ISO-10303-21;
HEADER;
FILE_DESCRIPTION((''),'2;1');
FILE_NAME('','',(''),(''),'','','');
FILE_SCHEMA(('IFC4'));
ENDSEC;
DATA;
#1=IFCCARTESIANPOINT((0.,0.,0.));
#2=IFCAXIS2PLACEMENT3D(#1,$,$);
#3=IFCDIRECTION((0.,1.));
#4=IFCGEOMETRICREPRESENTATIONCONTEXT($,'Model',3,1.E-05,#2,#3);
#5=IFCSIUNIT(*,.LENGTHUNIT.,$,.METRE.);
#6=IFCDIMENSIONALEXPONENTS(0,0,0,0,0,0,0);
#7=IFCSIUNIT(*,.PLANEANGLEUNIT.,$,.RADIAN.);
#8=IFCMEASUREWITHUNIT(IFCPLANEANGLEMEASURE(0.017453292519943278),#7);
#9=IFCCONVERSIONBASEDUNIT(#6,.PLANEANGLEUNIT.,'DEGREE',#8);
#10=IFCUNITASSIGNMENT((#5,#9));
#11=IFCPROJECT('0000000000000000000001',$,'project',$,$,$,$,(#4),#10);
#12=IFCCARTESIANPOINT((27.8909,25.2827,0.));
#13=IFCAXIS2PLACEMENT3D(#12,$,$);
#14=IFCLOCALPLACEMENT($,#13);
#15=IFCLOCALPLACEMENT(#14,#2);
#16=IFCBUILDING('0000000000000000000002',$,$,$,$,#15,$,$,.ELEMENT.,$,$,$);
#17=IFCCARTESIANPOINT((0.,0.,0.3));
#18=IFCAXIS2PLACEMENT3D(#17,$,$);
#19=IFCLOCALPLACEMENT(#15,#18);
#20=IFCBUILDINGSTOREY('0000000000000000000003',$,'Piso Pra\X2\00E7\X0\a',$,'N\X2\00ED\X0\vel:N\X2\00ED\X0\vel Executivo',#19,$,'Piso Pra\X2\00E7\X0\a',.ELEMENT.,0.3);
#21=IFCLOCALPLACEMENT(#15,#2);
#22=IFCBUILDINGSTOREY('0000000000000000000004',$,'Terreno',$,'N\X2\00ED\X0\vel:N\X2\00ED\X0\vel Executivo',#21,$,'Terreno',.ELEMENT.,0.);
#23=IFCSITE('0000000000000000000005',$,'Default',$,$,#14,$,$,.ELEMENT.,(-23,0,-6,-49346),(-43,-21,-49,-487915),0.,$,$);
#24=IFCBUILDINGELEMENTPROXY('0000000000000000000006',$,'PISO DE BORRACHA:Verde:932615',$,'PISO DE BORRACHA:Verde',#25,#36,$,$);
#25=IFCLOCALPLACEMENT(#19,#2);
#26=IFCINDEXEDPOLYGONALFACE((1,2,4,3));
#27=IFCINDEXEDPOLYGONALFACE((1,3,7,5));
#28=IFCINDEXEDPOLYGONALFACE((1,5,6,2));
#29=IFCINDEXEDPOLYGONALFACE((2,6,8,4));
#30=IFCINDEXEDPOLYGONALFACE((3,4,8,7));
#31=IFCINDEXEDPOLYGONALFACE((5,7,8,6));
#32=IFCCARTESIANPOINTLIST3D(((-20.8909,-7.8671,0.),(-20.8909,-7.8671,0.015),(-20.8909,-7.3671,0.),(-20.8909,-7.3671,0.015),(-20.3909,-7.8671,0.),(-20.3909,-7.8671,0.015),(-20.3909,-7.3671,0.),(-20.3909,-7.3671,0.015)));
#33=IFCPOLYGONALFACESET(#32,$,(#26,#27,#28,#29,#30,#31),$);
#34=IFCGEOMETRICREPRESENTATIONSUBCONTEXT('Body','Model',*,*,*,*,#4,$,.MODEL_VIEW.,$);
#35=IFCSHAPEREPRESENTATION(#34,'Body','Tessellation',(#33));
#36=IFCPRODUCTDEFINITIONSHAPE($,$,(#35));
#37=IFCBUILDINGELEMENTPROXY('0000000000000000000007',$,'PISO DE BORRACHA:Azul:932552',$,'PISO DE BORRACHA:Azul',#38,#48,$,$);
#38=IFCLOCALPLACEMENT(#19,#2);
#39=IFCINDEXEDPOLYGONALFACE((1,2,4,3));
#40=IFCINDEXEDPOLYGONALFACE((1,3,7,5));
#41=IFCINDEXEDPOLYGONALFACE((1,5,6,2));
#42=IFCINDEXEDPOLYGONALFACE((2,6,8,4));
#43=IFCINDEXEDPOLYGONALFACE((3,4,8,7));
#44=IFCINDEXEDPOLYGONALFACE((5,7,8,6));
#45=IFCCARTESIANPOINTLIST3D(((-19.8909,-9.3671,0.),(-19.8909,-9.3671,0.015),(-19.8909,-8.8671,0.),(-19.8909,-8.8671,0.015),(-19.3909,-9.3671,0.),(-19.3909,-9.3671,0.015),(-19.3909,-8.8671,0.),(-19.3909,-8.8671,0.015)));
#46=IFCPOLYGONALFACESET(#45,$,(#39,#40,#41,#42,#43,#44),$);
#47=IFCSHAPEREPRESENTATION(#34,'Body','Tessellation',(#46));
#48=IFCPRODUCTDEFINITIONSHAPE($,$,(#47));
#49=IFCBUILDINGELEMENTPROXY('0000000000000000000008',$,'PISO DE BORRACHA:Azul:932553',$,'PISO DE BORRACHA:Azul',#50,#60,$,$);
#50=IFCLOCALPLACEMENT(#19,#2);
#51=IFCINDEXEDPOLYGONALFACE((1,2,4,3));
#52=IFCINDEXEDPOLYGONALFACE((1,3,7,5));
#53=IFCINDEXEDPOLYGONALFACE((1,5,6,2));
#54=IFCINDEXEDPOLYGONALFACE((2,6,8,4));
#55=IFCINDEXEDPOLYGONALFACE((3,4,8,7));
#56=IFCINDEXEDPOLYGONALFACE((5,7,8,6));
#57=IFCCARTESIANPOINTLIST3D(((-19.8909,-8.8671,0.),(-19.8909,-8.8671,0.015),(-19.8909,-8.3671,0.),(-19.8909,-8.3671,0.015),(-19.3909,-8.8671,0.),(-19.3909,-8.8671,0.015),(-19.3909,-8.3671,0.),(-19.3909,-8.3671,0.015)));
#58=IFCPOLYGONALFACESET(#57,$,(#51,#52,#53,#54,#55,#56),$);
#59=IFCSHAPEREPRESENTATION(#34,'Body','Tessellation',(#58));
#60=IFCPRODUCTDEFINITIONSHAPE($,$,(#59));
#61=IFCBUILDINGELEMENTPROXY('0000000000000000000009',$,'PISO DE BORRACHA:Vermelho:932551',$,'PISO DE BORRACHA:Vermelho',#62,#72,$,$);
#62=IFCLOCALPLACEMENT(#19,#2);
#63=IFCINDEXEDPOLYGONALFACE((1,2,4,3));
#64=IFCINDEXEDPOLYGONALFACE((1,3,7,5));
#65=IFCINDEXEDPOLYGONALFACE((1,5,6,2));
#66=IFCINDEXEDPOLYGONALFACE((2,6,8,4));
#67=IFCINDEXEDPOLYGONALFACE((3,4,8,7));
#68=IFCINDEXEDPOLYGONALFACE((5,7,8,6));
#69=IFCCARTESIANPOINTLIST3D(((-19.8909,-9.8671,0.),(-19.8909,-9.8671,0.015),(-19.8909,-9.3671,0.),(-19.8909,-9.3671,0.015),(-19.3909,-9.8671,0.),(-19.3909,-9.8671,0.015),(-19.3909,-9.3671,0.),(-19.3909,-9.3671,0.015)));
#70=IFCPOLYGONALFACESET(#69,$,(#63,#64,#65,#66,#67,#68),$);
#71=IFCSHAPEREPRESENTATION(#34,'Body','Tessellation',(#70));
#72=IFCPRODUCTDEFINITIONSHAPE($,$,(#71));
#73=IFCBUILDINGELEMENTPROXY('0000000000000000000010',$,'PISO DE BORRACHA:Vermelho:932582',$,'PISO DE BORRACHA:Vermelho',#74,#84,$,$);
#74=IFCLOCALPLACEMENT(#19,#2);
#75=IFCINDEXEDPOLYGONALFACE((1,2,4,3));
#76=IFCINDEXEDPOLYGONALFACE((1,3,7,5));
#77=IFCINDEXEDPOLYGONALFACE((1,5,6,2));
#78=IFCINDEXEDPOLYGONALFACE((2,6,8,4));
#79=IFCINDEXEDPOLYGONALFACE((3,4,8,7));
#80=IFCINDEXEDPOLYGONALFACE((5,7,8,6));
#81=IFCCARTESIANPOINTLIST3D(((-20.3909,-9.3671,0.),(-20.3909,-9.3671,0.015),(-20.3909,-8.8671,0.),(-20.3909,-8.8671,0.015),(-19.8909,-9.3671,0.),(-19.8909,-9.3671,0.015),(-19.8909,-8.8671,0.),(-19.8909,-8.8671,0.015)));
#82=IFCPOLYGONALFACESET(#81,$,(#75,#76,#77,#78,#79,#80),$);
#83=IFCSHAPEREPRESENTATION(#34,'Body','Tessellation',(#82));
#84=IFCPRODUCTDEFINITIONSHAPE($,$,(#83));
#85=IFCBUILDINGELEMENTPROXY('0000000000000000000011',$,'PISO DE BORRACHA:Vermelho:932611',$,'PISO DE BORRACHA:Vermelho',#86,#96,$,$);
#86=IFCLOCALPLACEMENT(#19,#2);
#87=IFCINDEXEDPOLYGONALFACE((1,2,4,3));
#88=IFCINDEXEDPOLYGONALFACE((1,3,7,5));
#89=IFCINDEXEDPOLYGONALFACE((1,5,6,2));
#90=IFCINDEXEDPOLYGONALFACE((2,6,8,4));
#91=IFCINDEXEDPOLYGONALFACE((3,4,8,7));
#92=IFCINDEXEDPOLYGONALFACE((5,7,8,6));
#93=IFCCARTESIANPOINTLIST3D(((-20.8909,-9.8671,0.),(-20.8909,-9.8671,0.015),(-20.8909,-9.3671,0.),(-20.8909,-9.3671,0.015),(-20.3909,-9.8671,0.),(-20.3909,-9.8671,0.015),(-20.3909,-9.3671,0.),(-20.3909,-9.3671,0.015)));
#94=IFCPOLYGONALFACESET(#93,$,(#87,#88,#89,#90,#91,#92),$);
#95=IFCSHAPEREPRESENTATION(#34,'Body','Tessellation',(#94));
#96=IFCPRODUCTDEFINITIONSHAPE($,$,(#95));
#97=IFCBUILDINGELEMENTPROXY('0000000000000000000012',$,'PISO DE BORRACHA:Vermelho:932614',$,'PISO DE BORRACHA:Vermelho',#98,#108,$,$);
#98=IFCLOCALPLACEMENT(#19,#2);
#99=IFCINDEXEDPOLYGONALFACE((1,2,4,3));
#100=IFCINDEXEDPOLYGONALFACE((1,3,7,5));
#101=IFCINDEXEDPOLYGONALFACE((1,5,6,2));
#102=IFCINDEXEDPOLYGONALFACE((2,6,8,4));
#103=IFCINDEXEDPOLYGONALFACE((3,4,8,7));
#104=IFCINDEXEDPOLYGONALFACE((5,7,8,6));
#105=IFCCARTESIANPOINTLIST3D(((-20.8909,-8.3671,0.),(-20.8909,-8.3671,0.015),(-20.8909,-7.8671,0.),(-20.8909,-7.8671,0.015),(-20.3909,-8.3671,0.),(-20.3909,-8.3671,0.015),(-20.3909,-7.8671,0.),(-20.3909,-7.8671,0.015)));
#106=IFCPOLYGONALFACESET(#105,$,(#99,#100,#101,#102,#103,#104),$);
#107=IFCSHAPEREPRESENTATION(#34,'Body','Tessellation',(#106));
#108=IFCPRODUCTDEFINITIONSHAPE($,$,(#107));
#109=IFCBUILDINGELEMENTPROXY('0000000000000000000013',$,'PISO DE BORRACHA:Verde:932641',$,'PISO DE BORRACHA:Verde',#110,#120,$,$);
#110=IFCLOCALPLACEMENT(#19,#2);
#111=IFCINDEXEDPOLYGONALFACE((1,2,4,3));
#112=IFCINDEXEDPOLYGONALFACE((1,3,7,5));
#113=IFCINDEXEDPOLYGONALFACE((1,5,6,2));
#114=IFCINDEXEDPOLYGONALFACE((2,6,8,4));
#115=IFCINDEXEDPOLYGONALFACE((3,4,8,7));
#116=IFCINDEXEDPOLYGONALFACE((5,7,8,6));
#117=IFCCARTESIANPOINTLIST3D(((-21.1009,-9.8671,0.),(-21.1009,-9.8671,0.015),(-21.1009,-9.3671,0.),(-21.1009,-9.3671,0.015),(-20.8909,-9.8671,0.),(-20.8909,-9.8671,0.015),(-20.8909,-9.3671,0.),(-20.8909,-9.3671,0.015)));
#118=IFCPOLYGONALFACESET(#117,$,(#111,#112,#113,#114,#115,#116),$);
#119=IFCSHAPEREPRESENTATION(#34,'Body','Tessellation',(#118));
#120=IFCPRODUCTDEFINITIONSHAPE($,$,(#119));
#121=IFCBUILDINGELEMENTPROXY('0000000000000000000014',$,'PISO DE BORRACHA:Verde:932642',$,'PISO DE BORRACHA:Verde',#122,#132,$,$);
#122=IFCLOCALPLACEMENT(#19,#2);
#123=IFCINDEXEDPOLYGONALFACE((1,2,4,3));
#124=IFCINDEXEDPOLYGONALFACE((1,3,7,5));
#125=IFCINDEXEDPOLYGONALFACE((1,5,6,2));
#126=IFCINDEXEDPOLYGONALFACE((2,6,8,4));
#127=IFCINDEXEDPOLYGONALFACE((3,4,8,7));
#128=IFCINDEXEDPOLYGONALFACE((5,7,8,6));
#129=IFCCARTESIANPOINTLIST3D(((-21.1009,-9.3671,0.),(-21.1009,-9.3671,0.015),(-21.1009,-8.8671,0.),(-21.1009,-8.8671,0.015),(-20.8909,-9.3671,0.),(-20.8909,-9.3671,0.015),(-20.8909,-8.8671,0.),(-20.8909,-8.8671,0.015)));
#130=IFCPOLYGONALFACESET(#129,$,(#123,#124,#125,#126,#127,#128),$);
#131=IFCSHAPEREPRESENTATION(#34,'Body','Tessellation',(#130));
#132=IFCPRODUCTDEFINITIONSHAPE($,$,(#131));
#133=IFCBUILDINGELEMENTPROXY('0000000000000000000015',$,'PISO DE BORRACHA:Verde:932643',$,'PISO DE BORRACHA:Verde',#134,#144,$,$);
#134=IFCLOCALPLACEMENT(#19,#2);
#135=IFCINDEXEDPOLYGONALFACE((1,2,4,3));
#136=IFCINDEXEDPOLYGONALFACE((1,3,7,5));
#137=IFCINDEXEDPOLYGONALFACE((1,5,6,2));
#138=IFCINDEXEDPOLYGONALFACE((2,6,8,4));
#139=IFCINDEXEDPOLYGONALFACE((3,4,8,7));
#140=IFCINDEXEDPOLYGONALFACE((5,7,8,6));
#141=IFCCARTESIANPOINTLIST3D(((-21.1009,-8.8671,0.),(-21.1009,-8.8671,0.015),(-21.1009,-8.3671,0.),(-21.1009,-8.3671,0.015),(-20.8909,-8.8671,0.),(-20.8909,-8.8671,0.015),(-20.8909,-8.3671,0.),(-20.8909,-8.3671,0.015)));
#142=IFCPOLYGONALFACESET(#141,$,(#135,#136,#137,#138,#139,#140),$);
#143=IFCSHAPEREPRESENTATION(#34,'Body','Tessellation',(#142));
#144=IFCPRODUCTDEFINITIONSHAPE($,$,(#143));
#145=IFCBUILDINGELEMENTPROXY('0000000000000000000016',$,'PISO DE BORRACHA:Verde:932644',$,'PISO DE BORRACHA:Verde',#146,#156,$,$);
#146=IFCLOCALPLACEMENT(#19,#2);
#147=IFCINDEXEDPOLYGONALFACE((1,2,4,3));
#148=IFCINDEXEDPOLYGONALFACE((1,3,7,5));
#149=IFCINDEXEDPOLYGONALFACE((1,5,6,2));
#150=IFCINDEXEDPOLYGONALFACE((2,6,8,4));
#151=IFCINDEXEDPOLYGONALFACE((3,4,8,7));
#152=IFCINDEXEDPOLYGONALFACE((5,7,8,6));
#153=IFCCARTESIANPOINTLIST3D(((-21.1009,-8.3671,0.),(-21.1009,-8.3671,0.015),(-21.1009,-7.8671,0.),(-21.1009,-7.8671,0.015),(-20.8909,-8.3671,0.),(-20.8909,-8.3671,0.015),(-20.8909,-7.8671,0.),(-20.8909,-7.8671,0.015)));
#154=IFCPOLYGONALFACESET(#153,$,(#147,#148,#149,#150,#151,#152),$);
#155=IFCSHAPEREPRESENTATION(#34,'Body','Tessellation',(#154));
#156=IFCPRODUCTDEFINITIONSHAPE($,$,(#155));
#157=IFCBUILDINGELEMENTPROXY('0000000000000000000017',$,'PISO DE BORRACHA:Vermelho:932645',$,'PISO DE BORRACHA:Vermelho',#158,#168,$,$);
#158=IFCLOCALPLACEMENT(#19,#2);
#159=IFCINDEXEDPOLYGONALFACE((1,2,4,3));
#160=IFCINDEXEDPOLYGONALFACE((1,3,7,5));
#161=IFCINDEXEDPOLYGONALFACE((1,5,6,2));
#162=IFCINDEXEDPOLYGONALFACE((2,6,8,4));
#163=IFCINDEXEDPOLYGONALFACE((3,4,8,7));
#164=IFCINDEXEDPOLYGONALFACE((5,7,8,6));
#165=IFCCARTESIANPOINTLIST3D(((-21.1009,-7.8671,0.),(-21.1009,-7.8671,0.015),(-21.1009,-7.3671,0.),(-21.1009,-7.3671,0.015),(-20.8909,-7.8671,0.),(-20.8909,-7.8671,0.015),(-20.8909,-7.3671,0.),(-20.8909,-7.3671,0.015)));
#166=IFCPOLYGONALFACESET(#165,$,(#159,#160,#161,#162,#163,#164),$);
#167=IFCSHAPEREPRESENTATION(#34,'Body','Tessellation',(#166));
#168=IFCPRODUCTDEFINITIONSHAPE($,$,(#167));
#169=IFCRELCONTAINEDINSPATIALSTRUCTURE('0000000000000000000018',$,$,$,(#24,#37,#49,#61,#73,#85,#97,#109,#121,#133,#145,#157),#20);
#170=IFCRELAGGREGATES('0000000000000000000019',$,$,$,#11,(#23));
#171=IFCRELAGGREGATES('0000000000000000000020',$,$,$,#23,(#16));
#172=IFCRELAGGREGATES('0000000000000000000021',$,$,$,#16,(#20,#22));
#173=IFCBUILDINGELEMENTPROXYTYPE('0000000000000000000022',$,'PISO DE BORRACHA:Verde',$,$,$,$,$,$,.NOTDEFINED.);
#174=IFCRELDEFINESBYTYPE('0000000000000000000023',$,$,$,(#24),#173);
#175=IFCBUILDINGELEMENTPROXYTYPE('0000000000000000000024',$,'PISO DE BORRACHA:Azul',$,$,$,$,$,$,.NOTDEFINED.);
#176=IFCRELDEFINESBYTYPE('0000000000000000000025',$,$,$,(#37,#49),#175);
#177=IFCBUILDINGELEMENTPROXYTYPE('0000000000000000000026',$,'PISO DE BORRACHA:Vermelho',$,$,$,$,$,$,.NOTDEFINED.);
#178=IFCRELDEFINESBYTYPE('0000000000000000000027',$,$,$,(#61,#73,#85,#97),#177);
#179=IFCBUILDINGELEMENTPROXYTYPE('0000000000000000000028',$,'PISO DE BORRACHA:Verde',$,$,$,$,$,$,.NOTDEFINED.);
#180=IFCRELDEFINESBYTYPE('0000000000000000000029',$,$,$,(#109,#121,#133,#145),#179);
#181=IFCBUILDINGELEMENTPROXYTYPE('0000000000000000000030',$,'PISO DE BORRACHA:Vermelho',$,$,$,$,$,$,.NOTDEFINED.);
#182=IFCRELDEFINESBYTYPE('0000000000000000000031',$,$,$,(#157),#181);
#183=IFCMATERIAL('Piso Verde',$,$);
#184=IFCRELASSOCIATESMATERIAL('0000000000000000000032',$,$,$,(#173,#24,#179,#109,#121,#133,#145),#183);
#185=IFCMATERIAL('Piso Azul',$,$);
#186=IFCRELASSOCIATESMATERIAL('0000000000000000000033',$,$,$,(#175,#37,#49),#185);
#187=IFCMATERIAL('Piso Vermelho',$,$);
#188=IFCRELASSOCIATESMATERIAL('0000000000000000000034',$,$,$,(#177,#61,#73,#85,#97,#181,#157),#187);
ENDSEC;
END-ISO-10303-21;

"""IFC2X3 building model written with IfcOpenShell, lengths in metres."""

from ifc_helpers import new_model, entity, si_unit, converted_unit, direction, frame, origin, origin_2d_with_axis, place, context, subcontext, project, spatial, rectangle, extrude, source, transform, mapped, material, type_object, type_shapes, element, save


model = new_model("IFC2X3")

# Units and contexts
model_context = context("Model", 3, precision=1e-05, world=origin(), true_north=direction((0.0, 1.0)))
body_context = subcontext(model_context, "Body", "Model", "MODEL_VIEW")
ifc_project = project(units=[si_unit("LENGTHUNIT", "METRE"), converted_unit("PLANEANGLEUNIT", "DEGREE", entity("IfcPlaneAngleMeasure", 0.017453292519943278), si_unit("PLANEANGLEUNIT", "RADIAN"), dimensions=[0, 0, 0, 0, 0, 0, 0])], contexts=[model_context])

# Site, building, storey
site_placement = place(None, frame((27.8909, 25.2827, 0.0)))
site = spatial("IfcSite", under=ifc_project, at=site_placement, Name="Default", CompositionType="ELEMENT", RefLatitude=(-23, 0, -6, -49346), RefLongitude=(-43, -21, -49, -487915), RefElevation=0.0)
building_placement = place(site_placement, origin())
building = spatial("IfcBuilding", under=site, at=building_placement, CompositionType="ELEMENT")
storey_1_placement = place(building_placement, frame((0.0, 0.0, 0.3)))
storey_1 = spatial("IfcBuildingStorey", under=building, at=storey_1_placement, Name="Piso Praça", ObjectType="Nível:Nível Executivo", LongName="Piso Praça", CompositionType="ELEMENT", Elevation=0.3)

# Shared definitions
storey_2_placement = place(building_placement, origin())
storey_2 = spatial("IfcBuildingStorey", under=building, at=storey_2_placement, Name="Terreno", ObjectType="Nível:Nível Executivo", LongName="Terreno", CompositionType="ELEMENT", Elevation=0.0)

# Building element proxies
ifc_material_1 = material(Name="Piso Verde")
building_element_proxy_type_1 = type_object("IfcBuildingElementProxyType", Name="PISO DE BORRACHA:Verde", PredefinedType="NOTDEFINED", material=ifc_material_1)
shared_shape_1 = source(origin(), body_context, "Body", "SweptSolid", [
    extrude(rectangle(XDim=0.5, YDim=0.5, at=origin_2d_with_axis()), frame((0.25, 0.25, 0.0), z_axis=(0.0, 0.0, 1.0), x_axis=(-1.0, 0.0, 0.0)), (0.0, 0.0, 1.0), 0.015),
])
type_shapes(building_element_proxy_type_1, [shared_shape_1])
for number, where, z_axis, x_axis, name in (
    (1, (-20.8909, -7.3671, 0.0), (0.0, 0.0, 1.0), (0.0, -1.0, 0.0), "PISO DE BORRACHA:Verde:932615"),
):
    element("IfcBuildingElementProxy", number, at=place(storey_1_placement, frame(where, z_axis=z_axis, x_axis=x_axis)), inside=storey_1, type_object=building_element_proxy_type_1, material=ifc_material_1, Name=name, ObjectType="PISO DE BORRACHA:Verde", context=body_context, shape_type="MappedRepresentation", body=[
        mapped(shared_shape_1, transform((0.0, 0.0, 0.0), scale=1.0)),
    ])
ifc_material_2 = material(Name="Piso Azul")
building_element_proxy_type_2 = type_object("IfcBuildingElementProxyType", Name="PISO DE BORRACHA:Azul", PredefinedType="NOTDEFINED", material=ifc_material_2)
shared_shape_2 = source(origin(), body_context, "Body", "SweptSolid", [
    extrude(rectangle(XDim=0.5, YDim=0.5, at=origin_2d_with_axis()), frame((0.25, 0.25, 0.0), z_axis=(0.0, 0.0, 1.0), x_axis=(-1.0, 0.0, 0.0)), (0.0, 0.0, 1.0), 0.015),
])
type_shapes(building_element_proxy_type_2, [shared_shape_2])
for number, where, z_axis, x_axis, name in (
    (2, (-19.8909, -8.8671, 0.0), (0.0, 0.0, 1.0), (0.0, -1.0, 0.0), "PISO DE BORRACHA:Azul:932552"),
    (3, (-19.8909, -8.3671, 0.0), (0.0, 0.0, 1.0), (0.0, -1.0, 0.0), "PISO DE BORRACHA:Azul:932553"),
):
    element("IfcBuildingElementProxy", number, at=place(storey_1_placement, frame(where, z_axis=z_axis, x_axis=x_axis)), inside=storey_1, type_object=building_element_proxy_type_2, material=ifc_material_2, Name=name, ObjectType="PISO DE BORRACHA:Azul", context=body_context, shape_type="MappedRepresentation", body=[
        mapped(shared_shape_2, transform((0.0, 0.0, 0.0), scale=1.0)),
    ])
ifc_material_3 = material(Name="Piso Vermelho")
building_element_proxy_type_3 = type_object("IfcBuildingElementProxyType", Name="PISO DE BORRACHA:Vermelho", PredefinedType="NOTDEFINED", material=ifc_material_3)
shared_shape_3 = source(origin(), body_context, "Body", "SweptSolid", [
    extrude(rectangle(XDim=0.5, YDim=0.5, at=origin_2d_with_axis()), frame((0.25, 0.25, 0.0), z_axis=(0.0, 0.0, 1.0), x_axis=(-1.0, 0.0, 0.0)), (0.0, 0.0, 1.0), 0.015),
])
type_shapes(building_element_proxy_type_3, [shared_shape_3])
for number, where, z_axis, x_axis, name in (
    (4, (-19.8909, -9.3671, 0.0), (0.0, 0.0, 1.0), (0.0, -1.0, 0.0), "PISO DE BORRACHA:Vermelho:932551"),
    (5, (-20.3909, -8.8671, 0.0), (0.0, 0.0, 1.0), (0.0, -1.0, 0.0), "PISO DE BORRACHA:Vermelho:932582"),
    (6, (-20.8909, -9.3671, 0.0), (0.0, 0.0, 1.0), (0.0, -1.0, 0.0), "PISO DE BORRACHA:Vermelho:932611"),
    (7, (-20.8909, -7.8671, 0.0), (0.0, 0.0, 1.0), (0.0, -1.0, 0.0), "PISO DE BORRACHA:Vermelho:932614"),
):
    element("IfcBuildingElementProxy", number, at=place(storey_1_placement, frame(where, z_axis=z_axis, x_axis=x_axis)), inside=storey_1, type_object=building_element_proxy_type_3, material=ifc_material_3, Name=name, ObjectType="PISO DE BORRACHA:Vermelho", context=body_context, shape_type="MappedRepresentation", body=[
        mapped(shared_shape_3, transform((0.0, 0.0, 0.0), scale=1.0)),
    ])
building_element_proxy_type_4 = type_object("IfcBuildingElementProxyType", Name="PISO DE BORRACHA:Verde", PredefinedType="NOTDEFINED", material=ifc_material_1)
shared_shape_4 = source(origin(), body_context, "Body", "SweptSolid", [
    extrude(rectangle(XDim=0.5, YDim=0.21, at=origin_2d_with_axis()), frame((0.25, 0.105, 0.0), z_axis=(0.0, 0.0, 1.0), x_axis=(-1.0, 0.0, 0.0)), (0.0, 0.0, 1.0), 0.015),
])
type_shapes(building_element_proxy_type_4, [shared_shape_4])
for number, where, z_axis, x_axis, name in (
    (8, (-21.1009, -9.3671, 0.0), (0.0, 0.0, 1.0), (0.0, -1.0, 0.0), "PISO DE BORRACHA:Verde:932641"),
    (9, (-21.1009, -8.8671, 0.0), (0.0, 0.0, 1.0), (0.0, -1.0, 0.0), "PISO DE BORRACHA:Verde:932642"),
    (10, (-21.1009, -8.3671, 0.0), (0.0, 0.0, 1.0), (0.0, -1.0, 0.0), "PISO DE BORRACHA:Verde:932643"),
    (11, (-21.1009, -7.8671, 0.0), (0.0, 0.0, 1.0), (0.0, -1.0, 0.0), "PISO DE BORRACHA:Verde:932644"),
):
    element("IfcBuildingElementProxy", number, at=place(storey_1_placement, frame(where, z_axis=z_axis, x_axis=x_axis)), inside=storey_1, type_object=building_element_proxy_type_4, material=ifc_material_1, Name=name, ObjectType="PISO DE BORRACHA:Verde", context=body_context, shape_type="MappedRepresentation", body=[
        mapped(shared_shape_4, transform((0.0, 0.0, 0.0), scale=1.0)),
    ])
building_element_proxy_type_5 = type_object("IfcBuildingElementProxyType", Name="PISO DE BORRACHA:Vermelho", PredefinedType="NOTDEFINED", material=ifc_material_3)
shared_shape_5 = source(origin(), body_context, "Body", "SweptSolid", [
    extrude(rectangle(XDim=0.5, YDim=0.21, at=origin_2d_with_axis()), frame((0.25, 0.105, 0.0), z_axis=(0.0, 0.0, 1.0), x_axis=(-1.0, 0.0, 0.0)), (0.0, 0.0, 1.0), 0.015),
])
type_shapes(building_element_proxy_type_5, [shared_shape_5])
proxy_1_placement = place(storey_1_placement, frame((-21.1009, -7.3671, 0.0), z_axis=(0.0, 0.0, 1.0), x_axis=(0.0, -1.0, 0.0)))
element("IfcBuildingElementProxy", 12, at=proxy_1_placement, inside=storey_1, type_object=building_element_proxy_type_5, material=ifc_material_3, Name="PISO DE BORRACHA:Vermelho:932645", ObjectType="PISO DE BORRACHA:Vermelho", context=body_context, shape_type="MappedRepresentation", body=[
    mapped(shared_shape_5, transform((0.0, 0.0, 0.0), scale=1.0)),
])

save(model, "model.ifc")
